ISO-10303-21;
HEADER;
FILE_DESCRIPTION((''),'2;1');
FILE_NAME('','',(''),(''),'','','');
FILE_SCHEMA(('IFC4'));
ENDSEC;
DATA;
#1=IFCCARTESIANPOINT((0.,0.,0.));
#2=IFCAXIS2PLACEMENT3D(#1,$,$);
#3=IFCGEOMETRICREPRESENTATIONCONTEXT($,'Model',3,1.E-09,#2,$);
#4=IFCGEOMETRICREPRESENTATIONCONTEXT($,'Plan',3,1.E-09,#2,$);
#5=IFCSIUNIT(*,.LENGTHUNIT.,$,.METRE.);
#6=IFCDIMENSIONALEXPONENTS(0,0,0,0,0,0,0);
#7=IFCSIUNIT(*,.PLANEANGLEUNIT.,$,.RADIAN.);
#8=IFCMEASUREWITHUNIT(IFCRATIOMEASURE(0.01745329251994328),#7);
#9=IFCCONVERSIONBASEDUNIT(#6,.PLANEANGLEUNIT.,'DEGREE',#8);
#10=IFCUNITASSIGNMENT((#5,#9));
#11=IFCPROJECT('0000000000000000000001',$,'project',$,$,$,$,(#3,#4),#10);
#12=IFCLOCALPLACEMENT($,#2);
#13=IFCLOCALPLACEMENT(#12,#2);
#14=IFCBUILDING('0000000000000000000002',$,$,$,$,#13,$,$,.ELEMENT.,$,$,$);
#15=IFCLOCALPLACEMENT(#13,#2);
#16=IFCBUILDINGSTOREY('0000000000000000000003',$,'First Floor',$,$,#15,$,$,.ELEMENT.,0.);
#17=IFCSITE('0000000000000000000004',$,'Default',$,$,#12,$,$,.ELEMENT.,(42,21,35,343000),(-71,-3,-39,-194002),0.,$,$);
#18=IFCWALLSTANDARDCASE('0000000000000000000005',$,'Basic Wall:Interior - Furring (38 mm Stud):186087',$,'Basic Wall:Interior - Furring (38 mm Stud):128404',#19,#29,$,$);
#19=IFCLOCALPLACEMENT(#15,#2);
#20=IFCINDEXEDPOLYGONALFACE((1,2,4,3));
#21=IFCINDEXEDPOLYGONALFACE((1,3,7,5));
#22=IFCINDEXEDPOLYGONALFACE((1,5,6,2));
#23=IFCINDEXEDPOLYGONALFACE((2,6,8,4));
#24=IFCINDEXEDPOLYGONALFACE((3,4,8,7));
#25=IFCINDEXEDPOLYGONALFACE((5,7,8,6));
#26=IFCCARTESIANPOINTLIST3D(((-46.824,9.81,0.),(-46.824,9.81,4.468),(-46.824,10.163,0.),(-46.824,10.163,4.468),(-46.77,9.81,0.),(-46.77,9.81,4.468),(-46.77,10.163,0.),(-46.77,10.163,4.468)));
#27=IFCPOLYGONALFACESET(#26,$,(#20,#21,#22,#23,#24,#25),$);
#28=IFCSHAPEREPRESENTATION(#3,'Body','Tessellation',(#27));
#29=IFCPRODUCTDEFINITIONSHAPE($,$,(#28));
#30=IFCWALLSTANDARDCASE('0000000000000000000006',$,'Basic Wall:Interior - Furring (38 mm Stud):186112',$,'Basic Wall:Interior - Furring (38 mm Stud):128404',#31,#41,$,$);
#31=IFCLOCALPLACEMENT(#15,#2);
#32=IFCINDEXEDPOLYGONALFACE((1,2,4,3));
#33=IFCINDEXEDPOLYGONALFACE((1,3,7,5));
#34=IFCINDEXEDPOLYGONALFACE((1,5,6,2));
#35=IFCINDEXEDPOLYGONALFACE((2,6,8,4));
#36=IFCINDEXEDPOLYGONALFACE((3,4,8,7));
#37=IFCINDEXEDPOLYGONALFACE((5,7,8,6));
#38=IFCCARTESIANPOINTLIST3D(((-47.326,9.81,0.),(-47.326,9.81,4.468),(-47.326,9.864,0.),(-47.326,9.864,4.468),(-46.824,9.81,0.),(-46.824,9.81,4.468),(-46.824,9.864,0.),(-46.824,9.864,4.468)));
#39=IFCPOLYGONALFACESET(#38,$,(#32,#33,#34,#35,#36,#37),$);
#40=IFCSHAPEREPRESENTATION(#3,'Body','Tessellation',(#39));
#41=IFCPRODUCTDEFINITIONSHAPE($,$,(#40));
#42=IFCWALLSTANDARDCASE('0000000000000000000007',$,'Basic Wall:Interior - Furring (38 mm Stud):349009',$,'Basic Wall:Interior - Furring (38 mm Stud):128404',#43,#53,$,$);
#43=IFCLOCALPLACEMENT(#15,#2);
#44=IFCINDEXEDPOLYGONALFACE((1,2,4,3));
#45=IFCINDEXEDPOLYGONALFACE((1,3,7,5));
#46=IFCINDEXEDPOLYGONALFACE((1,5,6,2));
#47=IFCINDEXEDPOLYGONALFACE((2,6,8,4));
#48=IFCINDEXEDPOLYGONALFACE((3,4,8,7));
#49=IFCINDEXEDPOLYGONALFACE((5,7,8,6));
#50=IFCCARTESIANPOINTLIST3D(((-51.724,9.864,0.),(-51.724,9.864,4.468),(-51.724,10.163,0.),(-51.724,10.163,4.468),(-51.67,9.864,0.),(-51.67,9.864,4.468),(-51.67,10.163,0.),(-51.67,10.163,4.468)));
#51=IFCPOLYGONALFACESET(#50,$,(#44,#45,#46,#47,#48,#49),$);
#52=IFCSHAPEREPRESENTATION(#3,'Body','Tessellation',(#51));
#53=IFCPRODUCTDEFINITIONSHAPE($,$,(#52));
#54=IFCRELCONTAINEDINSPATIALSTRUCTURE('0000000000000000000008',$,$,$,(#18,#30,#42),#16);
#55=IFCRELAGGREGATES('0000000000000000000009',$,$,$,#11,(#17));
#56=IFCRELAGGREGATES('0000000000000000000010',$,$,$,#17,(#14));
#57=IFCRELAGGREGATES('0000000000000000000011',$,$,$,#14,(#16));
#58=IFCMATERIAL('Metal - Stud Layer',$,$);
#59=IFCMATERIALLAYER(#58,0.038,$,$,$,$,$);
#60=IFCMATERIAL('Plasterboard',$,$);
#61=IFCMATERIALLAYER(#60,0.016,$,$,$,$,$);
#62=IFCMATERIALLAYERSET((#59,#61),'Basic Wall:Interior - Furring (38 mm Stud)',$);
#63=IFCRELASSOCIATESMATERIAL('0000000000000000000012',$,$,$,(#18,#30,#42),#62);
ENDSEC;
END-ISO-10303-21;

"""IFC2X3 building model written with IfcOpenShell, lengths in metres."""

from ifc_helpers import new_model, entity, si_unit, converted_unit, frame, frame_2d, origin, place, context, project, spatial, rectangle, extrude, material, layer, layer_set, layer_usage, element, save


model = new_model("IFC2X3")

# Units and contexts
model_context = context("Model", 3, precision=1e-09, world=origin())
plan_context = context("Plan", 3, precision=1e-09, world=origin())
ifc_project = project(units=[si_unit("LENGTHUNIT", "METRE"), converted_unit("PLANEANGLEUNIT", "DEGREE", entity("IfcRatioMeasure", 0.01745329251994328), si_unit("PLANEANGLEUNIT", "RADIAN"), dimensions=[0, 0, 0, 0, 0, 0, 0])], contexts=[model_context, plan_context])

# Site, building, storey
site_placement = place(None, origin())
site = spatial("IfcSite", under=ifc_project, at=site_placement, Name="Default", CompositionType="ELEMENT", RefLatitude=(42, 21, 35, 343000), RefLongitude=(-71, -3, -39, -194002), RefElevation=0.0)
building_placement = place(site_placement, origin())
building = spatial("IfcBuilding", under=site, at=building_placement, CompositionType="ELEMENT")
storey_placement = place(building_placement, origin())
storey = spatial("IfcBuildingStorey", under=building, at=storey_placement, Name="First Floor", CompositionType="ELEMENT", Elevation=0.0)

# Shared definitions
ifc_material_1 = material(Name="Metal - Stud Layer")
ifc_material_2 = material(Name="Plasterboard")
ifc_layer_1 = layer(ifc_material_2, 0.016)

# Walls
ifc_layer_2 = layer(ifc_material_1, 0.038)
ifc_layer_set_1 = layer_set([ifc_layer_2, ifc_layer_1], Name="Basic Wall:Interior - Furring (38 mm Stud)")
ifc_layer_usage_1 = layer_usage(ifc_layer_set_1, "AXIS2", "POSITIVE", -0.027)
wall_1_placement = place(storey_placement, frame((-46.797, 10.163, 0.0), z_axis=(0.0, 0.0, 1.0), x_axis=(0.0, -1.0, 0.0)))
element("IfcWallStandardCase", 1, at=wall_1_placement, inside=storey, material=ifc_layer_usage_1, Name="Basic Wall:Interior - Furring (38 mm Stud):186087", ObjectType="Basic Wall:Interior - Furring (38 mm Stud):128404", context=model_context, shape_type="SweptSolid", body=[
    extrude(rectangle(XDim=0.353, YDim=0.054, at=frame_2d((0.1765, 0.0), x_axis=(-1.0, 0.0))), origin(), (0.0, 0.0, 1.0), 4.468),
])
wall_2_placement = place(storey_placement, frame((-46.824, 9.837, 0.0), z_axis=(0.0, 0.0, 1.0), x_axis=(-1.0, 0.0, 0.0)))
element("IfcWallStandardCase", 2, at=wall_2_placement, inside=storey, material=ifc_layer_usage_1, Name="Basic Wall:Interior - Furring (38 mm Stud):186112", ObjectType="Basic Wall:Interior - Furring (38 mm Stud):128404", context=model_context, shape_type="SweptSolid", body=[
    extrude(rectangle(XDim=0.502, YDim=0.054, at=frame_2d((0.251, 0.0), x_axis=(-1.0, 0.0))), origin(), (0.0, 0.0, 1.0), 4.468),
])
ifc_layer_usage_2 = layer_usage(ifc_layer_set_1, "AXIS2", "NEGATIVE", 0.027)
wall_3_placement = place(storey_placement, frame((-51.697, 9.864, 0.0), z_axis=(0.0, 0.0, 1.0), x_axis=(0.0, 1.0, 0.0)))
element("IfcWallStandardCase", 3, at=wall_3_placement, inside=storey, material=ifc_layer_usage_2, Name="Basic Wall:Interior - Furring (38 mm Stud):349009", ObjectType="Basic Wall:Interior - Furring (38 mm Stud):128404", context=model_context, shape_type="SweptSolid", body=[
    extrude(rectangle(XDim=0.299, YDim=0.054, at=frame_2d((0.1495, 0.0), x_axis=(-1.0, 0.0))), origin(), (0.0, 0.0, 1.0), 4.468),
])

save(model, "model.ifc")
